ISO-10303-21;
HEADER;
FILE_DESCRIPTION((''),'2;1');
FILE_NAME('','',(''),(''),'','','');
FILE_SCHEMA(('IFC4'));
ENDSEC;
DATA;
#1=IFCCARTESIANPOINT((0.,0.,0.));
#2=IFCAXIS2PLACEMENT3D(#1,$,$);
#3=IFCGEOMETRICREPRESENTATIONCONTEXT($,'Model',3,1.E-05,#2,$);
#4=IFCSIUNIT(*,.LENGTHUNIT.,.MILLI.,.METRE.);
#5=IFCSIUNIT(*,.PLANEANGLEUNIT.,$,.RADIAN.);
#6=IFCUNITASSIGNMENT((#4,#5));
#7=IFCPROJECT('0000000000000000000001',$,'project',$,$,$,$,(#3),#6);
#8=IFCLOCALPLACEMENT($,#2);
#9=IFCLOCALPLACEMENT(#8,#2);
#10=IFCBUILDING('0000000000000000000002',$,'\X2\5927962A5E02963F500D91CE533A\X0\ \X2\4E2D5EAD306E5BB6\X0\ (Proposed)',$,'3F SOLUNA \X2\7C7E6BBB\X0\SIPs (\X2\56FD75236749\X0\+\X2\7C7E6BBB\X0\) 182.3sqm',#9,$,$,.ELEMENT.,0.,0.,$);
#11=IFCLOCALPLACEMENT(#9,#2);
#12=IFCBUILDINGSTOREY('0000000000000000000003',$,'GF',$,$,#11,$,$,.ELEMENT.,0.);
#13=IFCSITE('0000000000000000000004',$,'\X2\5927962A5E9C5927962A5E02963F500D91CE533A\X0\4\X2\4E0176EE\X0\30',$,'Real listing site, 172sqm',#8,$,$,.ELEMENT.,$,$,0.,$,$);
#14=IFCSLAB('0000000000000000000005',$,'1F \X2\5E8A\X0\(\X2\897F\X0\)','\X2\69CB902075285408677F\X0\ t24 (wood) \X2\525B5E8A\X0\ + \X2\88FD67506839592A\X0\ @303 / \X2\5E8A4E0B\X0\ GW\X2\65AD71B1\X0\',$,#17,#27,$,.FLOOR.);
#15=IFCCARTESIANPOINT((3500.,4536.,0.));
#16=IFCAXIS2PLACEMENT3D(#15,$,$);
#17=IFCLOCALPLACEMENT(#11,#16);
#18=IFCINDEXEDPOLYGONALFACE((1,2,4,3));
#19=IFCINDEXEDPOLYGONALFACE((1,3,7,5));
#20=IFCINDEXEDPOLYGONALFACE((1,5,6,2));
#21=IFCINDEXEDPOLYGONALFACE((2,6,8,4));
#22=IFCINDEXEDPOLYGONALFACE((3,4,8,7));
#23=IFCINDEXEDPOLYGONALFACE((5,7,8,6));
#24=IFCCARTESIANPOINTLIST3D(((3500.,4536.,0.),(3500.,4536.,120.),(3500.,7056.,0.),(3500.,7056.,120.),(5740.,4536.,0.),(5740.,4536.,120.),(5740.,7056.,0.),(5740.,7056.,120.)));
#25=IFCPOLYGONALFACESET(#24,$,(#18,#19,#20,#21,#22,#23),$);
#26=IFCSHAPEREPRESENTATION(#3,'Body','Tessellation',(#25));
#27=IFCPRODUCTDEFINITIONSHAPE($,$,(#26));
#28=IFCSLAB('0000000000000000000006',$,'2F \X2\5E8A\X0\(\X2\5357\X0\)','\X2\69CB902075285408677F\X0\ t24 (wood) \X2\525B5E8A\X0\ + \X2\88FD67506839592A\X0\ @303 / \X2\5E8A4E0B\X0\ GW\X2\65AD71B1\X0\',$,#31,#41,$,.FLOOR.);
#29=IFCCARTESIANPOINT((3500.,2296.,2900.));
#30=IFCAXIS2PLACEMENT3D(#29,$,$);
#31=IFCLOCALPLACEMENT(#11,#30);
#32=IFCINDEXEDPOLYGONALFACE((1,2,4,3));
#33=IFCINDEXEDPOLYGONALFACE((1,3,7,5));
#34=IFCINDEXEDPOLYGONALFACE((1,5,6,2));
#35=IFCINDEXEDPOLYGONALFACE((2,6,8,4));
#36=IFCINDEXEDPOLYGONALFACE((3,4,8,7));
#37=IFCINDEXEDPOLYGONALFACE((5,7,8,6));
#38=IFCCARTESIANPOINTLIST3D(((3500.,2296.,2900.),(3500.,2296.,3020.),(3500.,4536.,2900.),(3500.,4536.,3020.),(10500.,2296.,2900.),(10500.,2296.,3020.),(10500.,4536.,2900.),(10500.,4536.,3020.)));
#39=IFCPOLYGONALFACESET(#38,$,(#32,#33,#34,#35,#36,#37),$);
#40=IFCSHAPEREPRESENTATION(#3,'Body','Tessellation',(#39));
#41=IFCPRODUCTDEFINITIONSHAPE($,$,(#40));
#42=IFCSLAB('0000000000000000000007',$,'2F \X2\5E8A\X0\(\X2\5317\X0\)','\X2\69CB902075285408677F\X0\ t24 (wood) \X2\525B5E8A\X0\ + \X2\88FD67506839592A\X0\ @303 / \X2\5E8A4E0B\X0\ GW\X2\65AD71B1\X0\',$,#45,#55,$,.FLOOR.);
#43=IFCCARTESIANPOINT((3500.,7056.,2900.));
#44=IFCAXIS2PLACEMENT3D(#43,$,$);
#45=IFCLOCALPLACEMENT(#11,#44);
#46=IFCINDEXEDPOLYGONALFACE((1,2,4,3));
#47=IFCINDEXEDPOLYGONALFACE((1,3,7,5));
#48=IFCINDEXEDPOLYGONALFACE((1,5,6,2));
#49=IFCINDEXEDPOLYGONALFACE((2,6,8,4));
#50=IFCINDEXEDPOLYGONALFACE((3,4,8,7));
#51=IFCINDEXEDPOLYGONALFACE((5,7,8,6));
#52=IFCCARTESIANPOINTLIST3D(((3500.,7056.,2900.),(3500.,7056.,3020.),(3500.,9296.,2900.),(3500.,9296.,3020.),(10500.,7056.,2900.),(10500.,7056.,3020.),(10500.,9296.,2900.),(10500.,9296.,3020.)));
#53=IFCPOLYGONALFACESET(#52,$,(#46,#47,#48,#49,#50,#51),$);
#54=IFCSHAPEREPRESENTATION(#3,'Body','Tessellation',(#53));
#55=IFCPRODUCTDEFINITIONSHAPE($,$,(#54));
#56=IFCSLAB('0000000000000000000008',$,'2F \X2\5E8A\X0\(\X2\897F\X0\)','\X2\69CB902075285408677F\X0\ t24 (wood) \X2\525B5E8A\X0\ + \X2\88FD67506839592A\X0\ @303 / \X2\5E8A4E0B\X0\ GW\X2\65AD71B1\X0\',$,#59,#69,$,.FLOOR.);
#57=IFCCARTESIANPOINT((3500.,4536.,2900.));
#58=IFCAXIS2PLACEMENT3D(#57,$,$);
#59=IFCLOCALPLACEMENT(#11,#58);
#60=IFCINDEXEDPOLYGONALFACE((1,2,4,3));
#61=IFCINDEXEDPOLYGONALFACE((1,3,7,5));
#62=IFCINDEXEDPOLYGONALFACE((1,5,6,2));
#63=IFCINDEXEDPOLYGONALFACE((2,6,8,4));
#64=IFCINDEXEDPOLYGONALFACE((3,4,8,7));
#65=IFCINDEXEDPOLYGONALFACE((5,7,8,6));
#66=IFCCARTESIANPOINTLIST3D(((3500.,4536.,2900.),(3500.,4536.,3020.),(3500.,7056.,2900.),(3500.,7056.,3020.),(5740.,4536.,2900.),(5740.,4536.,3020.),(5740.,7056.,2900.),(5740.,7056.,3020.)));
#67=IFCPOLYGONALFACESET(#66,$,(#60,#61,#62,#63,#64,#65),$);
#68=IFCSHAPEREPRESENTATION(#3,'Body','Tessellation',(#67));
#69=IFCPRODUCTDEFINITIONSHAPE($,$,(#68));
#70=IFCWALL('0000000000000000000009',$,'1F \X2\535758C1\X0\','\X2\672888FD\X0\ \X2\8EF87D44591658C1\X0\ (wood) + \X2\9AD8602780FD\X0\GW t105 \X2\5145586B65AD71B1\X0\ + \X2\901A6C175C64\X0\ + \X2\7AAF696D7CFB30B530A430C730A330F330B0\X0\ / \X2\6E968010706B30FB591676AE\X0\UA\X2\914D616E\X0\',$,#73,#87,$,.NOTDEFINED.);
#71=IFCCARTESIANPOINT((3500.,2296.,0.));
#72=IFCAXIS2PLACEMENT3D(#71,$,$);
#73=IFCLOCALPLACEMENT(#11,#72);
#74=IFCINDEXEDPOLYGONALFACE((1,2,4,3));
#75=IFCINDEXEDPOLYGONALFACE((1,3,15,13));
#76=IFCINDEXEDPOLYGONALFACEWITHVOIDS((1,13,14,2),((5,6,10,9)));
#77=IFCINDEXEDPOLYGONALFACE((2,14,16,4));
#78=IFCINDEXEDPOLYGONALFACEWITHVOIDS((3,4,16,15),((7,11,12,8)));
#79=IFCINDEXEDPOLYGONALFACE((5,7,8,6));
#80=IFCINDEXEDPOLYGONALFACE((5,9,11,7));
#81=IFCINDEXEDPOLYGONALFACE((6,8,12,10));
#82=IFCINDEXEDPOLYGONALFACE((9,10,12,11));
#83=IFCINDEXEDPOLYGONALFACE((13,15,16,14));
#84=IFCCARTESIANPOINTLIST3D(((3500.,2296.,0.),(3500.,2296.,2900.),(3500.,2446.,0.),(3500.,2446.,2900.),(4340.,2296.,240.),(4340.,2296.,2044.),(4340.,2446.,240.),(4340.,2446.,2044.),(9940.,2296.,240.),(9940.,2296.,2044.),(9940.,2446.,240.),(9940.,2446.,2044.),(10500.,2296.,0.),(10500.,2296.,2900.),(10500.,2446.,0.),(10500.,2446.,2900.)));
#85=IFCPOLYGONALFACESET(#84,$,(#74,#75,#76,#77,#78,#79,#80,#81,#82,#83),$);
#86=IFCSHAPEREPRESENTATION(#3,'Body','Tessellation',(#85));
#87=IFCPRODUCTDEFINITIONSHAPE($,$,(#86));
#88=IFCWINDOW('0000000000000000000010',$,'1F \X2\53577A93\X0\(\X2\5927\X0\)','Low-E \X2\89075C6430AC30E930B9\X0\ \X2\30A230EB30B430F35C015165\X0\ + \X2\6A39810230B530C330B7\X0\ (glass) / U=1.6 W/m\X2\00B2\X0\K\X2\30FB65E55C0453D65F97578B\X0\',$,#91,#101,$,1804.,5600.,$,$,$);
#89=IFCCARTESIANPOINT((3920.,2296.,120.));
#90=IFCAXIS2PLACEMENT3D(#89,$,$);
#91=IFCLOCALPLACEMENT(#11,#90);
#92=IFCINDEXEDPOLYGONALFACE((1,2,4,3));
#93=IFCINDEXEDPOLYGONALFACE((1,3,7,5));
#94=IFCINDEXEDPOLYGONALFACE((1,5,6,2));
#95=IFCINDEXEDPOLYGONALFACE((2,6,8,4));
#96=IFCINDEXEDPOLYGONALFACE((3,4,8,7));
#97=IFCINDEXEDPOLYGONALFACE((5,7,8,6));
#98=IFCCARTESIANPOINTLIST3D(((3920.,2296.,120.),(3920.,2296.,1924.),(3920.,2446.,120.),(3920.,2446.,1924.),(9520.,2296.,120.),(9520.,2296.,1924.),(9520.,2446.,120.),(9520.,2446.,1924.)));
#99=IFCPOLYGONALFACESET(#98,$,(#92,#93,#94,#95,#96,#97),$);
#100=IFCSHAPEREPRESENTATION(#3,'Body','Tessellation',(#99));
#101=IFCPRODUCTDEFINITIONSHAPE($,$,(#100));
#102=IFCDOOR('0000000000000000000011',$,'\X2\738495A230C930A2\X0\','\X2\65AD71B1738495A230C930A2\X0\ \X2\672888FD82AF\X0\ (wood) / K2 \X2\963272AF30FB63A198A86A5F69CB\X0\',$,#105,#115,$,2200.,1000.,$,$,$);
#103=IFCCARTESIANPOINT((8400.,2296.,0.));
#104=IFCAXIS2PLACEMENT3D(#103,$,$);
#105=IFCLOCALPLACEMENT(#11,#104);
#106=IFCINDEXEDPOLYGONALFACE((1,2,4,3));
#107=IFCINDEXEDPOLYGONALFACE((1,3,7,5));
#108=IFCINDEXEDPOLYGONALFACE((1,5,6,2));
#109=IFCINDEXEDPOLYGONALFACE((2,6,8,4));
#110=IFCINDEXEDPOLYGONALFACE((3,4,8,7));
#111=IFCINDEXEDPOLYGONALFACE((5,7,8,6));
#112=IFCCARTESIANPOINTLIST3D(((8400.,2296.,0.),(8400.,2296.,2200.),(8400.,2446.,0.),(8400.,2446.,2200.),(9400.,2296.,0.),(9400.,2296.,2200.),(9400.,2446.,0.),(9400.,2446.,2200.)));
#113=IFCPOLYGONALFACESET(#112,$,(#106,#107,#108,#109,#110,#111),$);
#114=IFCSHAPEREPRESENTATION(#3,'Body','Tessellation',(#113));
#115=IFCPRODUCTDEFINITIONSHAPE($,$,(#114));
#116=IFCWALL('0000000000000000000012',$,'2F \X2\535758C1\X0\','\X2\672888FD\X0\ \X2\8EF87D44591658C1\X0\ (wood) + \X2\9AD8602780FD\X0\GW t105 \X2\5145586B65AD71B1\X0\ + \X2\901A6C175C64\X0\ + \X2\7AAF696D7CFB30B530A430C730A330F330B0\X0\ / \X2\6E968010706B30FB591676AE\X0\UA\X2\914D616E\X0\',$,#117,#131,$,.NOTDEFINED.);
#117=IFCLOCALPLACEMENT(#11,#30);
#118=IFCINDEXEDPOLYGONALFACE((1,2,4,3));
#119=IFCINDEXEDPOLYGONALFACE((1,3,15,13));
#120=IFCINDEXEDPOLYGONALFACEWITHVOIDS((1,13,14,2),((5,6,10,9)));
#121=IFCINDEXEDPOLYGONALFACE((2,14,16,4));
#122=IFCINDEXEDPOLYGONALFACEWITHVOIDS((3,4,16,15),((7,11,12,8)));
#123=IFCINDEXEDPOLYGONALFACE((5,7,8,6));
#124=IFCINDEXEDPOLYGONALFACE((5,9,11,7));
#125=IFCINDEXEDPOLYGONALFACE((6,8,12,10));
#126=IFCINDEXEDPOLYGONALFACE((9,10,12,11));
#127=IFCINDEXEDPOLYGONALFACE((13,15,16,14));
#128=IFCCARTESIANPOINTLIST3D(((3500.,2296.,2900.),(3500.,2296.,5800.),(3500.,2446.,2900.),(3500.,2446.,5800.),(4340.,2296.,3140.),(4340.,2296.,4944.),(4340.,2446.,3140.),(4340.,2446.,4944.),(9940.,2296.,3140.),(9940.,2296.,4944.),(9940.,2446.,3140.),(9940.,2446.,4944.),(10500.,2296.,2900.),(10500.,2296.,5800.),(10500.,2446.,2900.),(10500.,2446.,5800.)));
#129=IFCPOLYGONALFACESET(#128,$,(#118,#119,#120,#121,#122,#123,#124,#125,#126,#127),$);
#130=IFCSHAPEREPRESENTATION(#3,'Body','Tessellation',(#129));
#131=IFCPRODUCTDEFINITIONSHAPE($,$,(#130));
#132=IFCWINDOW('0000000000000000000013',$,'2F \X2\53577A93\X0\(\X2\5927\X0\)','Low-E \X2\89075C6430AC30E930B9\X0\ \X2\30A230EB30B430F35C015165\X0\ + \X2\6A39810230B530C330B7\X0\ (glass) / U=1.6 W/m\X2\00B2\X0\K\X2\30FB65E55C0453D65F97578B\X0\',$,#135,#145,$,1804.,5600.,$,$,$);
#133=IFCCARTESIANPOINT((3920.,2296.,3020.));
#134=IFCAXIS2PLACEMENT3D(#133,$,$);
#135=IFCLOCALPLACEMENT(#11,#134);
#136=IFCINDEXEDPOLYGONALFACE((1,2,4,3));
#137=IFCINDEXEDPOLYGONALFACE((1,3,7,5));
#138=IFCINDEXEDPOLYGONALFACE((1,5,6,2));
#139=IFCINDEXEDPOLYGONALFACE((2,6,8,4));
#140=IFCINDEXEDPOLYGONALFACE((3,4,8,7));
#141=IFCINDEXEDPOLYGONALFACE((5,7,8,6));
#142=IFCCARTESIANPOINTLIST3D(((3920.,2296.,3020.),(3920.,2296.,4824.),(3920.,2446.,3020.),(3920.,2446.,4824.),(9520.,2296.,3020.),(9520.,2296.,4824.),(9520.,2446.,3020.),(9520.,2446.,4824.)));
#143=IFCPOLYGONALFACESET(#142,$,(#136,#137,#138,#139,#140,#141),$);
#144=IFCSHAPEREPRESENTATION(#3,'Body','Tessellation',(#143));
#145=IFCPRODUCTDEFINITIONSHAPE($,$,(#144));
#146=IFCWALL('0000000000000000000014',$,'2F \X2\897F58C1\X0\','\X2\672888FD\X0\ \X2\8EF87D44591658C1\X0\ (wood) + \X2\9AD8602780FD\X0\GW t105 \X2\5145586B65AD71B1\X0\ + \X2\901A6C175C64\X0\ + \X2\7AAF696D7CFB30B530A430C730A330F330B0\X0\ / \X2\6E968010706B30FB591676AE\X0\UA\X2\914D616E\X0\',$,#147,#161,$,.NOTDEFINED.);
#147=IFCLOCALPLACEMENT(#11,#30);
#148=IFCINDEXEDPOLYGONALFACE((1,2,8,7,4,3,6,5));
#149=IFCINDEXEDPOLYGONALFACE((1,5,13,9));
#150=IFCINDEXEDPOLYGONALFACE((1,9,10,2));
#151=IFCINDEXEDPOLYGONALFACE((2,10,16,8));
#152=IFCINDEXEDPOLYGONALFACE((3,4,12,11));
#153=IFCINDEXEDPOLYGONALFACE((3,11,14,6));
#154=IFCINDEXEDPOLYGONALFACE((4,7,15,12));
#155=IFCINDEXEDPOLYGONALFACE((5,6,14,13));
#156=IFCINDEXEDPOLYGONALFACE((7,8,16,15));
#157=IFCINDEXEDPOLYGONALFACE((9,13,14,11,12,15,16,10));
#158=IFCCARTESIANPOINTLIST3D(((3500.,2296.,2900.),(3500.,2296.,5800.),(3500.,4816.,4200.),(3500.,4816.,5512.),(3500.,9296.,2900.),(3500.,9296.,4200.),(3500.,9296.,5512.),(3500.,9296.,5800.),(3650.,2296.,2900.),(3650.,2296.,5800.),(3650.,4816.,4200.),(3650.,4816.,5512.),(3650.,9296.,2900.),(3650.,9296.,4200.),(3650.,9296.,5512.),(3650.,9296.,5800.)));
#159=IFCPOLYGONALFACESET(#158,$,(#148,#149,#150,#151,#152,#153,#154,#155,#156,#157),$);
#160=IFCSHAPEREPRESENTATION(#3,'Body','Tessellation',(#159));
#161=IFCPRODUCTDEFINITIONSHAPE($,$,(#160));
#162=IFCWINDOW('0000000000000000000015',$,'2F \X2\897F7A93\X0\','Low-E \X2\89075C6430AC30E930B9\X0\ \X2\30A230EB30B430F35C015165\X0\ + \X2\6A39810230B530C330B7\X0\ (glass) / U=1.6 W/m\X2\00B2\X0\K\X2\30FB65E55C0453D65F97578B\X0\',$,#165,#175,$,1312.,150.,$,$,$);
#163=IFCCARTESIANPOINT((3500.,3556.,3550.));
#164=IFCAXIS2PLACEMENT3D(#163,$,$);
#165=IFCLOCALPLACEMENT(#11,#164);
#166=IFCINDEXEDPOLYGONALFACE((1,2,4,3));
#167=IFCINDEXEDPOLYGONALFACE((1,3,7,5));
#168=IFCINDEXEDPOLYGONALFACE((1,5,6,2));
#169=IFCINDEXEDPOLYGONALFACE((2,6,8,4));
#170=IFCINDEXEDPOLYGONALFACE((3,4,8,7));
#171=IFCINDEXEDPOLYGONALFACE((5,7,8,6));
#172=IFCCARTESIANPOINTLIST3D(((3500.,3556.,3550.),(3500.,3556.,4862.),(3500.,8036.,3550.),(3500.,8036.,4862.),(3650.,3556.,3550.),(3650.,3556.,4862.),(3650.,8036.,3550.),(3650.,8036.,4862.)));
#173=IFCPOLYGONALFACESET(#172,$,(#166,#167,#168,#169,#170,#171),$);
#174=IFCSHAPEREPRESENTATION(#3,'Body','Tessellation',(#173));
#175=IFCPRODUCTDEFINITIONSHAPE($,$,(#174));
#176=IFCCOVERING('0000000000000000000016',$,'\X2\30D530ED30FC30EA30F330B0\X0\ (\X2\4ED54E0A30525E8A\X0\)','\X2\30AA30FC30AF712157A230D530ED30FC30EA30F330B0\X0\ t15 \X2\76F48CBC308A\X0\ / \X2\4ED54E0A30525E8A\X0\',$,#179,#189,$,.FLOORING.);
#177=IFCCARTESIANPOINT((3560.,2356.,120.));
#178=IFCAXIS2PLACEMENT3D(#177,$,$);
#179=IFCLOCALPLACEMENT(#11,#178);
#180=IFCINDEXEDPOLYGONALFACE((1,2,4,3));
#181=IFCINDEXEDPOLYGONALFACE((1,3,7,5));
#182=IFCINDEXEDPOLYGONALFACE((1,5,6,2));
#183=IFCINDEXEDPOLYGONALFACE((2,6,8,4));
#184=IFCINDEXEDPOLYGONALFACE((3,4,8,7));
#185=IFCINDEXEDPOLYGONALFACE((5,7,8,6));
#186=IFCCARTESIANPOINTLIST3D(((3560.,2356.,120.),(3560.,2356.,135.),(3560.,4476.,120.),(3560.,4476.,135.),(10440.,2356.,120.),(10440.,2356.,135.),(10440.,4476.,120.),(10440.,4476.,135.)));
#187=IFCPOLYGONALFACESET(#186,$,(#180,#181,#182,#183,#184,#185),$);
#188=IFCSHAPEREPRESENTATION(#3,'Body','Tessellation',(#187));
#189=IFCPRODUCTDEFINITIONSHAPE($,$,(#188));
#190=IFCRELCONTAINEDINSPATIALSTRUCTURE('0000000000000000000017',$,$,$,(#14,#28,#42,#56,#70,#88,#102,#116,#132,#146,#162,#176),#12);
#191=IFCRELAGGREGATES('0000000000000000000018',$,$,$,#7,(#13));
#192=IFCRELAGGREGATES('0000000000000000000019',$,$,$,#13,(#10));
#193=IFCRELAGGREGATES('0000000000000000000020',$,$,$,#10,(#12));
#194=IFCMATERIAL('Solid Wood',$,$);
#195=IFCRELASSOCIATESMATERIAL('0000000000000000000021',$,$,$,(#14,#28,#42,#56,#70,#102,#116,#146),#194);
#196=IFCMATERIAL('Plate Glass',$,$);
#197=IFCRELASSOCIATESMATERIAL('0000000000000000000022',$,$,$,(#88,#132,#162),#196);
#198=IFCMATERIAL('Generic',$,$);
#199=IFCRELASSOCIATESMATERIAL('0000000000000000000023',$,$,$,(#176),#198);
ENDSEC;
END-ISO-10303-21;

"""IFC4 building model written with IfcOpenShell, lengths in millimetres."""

from ifc_helpers import new_model, si_unit, frame, frame_2d, origin, place, context, project, spatial, rectangle, extrude, material, element, fill, save


model = new_model("IFC4")

# Units and contexts
model_context = context("Model", 3, precision=1e-05, world=origin())
ifc_project = project(units=[si_unit("LENGTHUNIT", "METRE", prefix="MILLI"), si_unit("PLANEANGLEUNIT", "RADIAN")], contexts=[model_context])

# Site, building, storey
site_placement = place(None, origin())
site = spatial("IfcSite", under=ifc_project, at=site_placement, Name="大阪府大阪市阿倍野区4丁目30", ObjectType="Real listing site, 172sqm", CompositionType="ELEMENT", RefElevation=0.0)
building_placement = place(site_placement, origin())
building = spatial("IfcBuilding", under=site, at=building_placement, Name="大阪市阿倍野区 中庭の家 (Proposed)", ObjectType="3F SOLUNA 籾殻SIPs (国産杉+籾殻) 182.3sqm", CompositionType="ELEMENT", ElevationOfRefHeight=0.0, ElevationOfTerrain=0.0)
storey_placement = place(building_placement, origin())
storey = spatial("IfcBuildingStorey", under=building, at=storey_placement, Name="GF", CompositionType="ELEMENT", Elevation=0.0)

# Slabs
ifc_material_1 = material(Name="Solid Wood")
slab_1_placement = place(storey_placement, frame((3500.0, 4536.0, 0.0)))
element("IfcSlab", 1, at=slab_1_placement, inside=storey, material=ifc_material_1, Name="1F 床(西)", Description="構造用合板 t24 (wood) 剛床 + 製材根太 @303 / 床下 GW断熱", PredefinedType="FLOOR", context=model_context, shape_type="SweptSolid", body=[
    extrude(rectangle(XDim=2240.0, YDim=2520.0, at=frame_2d((1120.0, 1260.0))), frame((3500.0, 4536.0, 0.0)), (0.0, 0.0, 1.0), 120.0),
])
slab_2_placement = place(storey_placement, frame((3500.0, 2296.0, 2900.0)))
element("IfcSlab", 2, at=slab_2_placement, inside=storey, material=ifc_material_1, Name="2F 床(南)", Description="構造用合板 t24 (wood) 剛床 + 製材根太 @303 / 床下 GW断熱", PredefinedType="FLOOR", context=model_context, shape_type="SweptSolid", body=[
    extrude(rectangle(XDim=7000.0, YDim=2240.0, at=frame_2d((3500.0, 1120.0))), frame((3500.0, 2296.0, 2900.0)), (0.0, 0.0, 1.0), 120.0),
])
slab_3_placement = place(storey_placement, frame((3500.0, 7056.0, 2900.0)))
element("IfcSlab", 3, at=slab_3_placement, inside=storey, material=ifc_material_1, Name="2F 床(北)", Description="構造用合板 t24 (wood) 剛床 + 製材根太 @303 / 床下 GW断熱", PredefinedType="FLOOR", context=model_context, shape_type="SweptSolid", body=[
    extrude(rectangle(XDim=7000.0, YDim=2240.0, at=frame_2d((3500.0, 1120.0))), frame((3500.0, 7056.0, 2900.0)), (0.0, 0.0, 1.0), 120.0),
])
slab_4_placement = place(storey_placement, frame((3500.0, 4536.0, 2900.0)))
element("IfcSlab", 4, at=slab_4_placement, inside=storey, material=ifc_material_1, Name="2F 床(西)", Description="構造用合板 t24 (wood) 剛床 + 製材根太 @303 / 床下 GW断熱", PredefinedType="FLOOR", context=model_context, shape_type="SweptSolid", body=[
    extrude(rectangle(XDim=2240.0, YDim=2520.0, at=frame_2d((1120.0, 1260.0))), frame((3500.0, 4536.0, 2900.0)), (0.0, 0.0, 1.0), 120.0),
])

# Wall, openings, window, door
wall_1_placement = place(storey_placement, frame((3500.0, 2296.0, 0.0)))
wall_1 = element("IfcWall", 5, at=wall_1_placement, inside=storey, material=ifc_material_1, Name="1F 南壁", Description="木製 軸組外壁 (wood) + 高性能GW t105 充填断熱 + 通気層 + 窯業系サイディング / 準耐火・外皮UA配慮", PredefinedType="NOTDEFINED", context=model_context, shape_type="SweptSolid", body=[
    extrude(rectangle(XDim=7000.0, YDim=150.0, at=frame_2d((3500.0, 75.0))), frame((3500.0, 2296.0, 0.0)), (0.0, 0.0, 1.0), 2900.0),
])
opening_1_placement = place(storey_placement, frame((3920.0, 2296.0, 120.0)))
opening_1 = element("IfcOpeningElement", 6, at=opening_1_placement, cuts=wall_1, PredefinedType="NOTDEFINED", context=model_context, shape_type="SweptSolid", body=[
    extrude(rectangle(XDim=5600.0, YDim=150.0, at=frame_2d((2800.0, 75.0))), frame((3920.0, 2296.0, 120.0)), (0.0, 0.0, 1.0), 1804.0),
])
opening_2_placement = place(storey_placement, frame((8400.0, 2296.0, 0.0)))
opening_2 = element("IfcOpeningElement", 7, at=opening_2_placement, cuts=wall_1, PredefinedType="NOTDEFINED", context=model_context, shape_type="SweptSolid", body=[
    extrude(rectangle(XDim=1000.0, YDim=150.0, at=frame_2d((500.0, 75.0))), frame((8400.0, 2296.0, 0.0)), (0.0, 0.0, 1.0), 2200.0),
])
ifc_material_2 = material(Name="Plate Glass")
window_1_placement = place(storey_placement, frame((3920.0, 2296.0, 120.0)))
window_1 = element("IfcWindow", 8, at=window_1_placement, inside=storey, material=ifc_material_2, Name="1F 南窓(大)", Description="Low-E 複層ガラス アルゴン封入 + 樹脂サッシ (glass) / U=1.6 W/m²K・日射取得型", OverallHeight=1804.0, OverallWidth=5600.0, context=model_context, shape_type="SweptSolid", body=[
    extrude(rectangle(XDim=5600.0, YDim=150.0, at=frame_2d((2800.0, 75.0))), frame((3920.0, 2296.0, 120.0)), (0.0, 0.0, 1.0), 1804.0),
])
fill(opening_1, window_1)
door_placement = place(storey_placement, frame((8400.0, 2296.0, 0.0)))
door = element("IfcDoor", 9, at=door_placement, inside=storey, material=ifc_material_1, Name="玄関ドア", Description="断熱玄関ドア 木製芯 (wood) / K2 防犯・採風機構", OverallHeight=2200.0, OverallWidth=1000.0, context=model_context, shape_type="SweptSolid", body=[
    extrude(rectangle(XDim=1000.0, YDim=150.0, at=frame_2d((500.0, 75.0))), frame((8400.0, 2296.0, 0.0)), (0.0, 0.0, 1.0), 2200.0),
])
fill(opening_2, door)

# Wall, opening, window
wall_2_placement = place(storey_placement, frame((3500.0, 2296.0, 2900.0)))
wall_2 = element("IfcWall", 10, at=wall_2_placement, inside=storey, material=ifc_material_1, Name="2F 南壁", Description="木製 軸組外壁 (wood) + 高性能GW t105 充填断熱 + 通気層 + 窯業系サイディング / 準耐火・外皮UA配慮", PredefinedType="NOTDEFINED", context=model_context, shape_type="SweptSolid", body=[
    extrude(rectangle(XDim=7000.0, YDim=150.0, at=frame_2d((3500.0, 75.0))), frame((3500.0, 2296.0, 2900.0)), (0.0, 0.0, 1.0), 2900.0),
])
opening_3_placement = place(storey_placement, frame((3920.0, 2296.0, 3020.0)))
opening_3 = element("IfcOpeningElement", 11, at=opening_3_placement, cuts=wall_2, PredefinedType="NOTDEFINED", context=model_context, shape_type="SweptSolid", body=[
    extrude(rectangle(XDim=5600.0, YDim=150.0, at=frame_2d((2800.0, 75.0))), frame((3920.0, 2296.0, 3020.0)), (0.0, 0.0, 1.0), 1804.0),
])
window_2_placement = place(storey_placement, frame((3920.0, 2296.0, 3020.0)))
window_2 = element("IfcWindow", 12, at=window_2_placement, inside=storey, material=ifc_material_2, Name="2F 南窓(大)", Description="Low-E 複層ガラス アルゴン封入 + 樹脂サッシ (glass) / U=1.6 W/m²K・日射取得型", OverallHeight=1804.0, OverallWidth=5600.0, context=model_context, shape_type="SweptSolid", body=[
    extrude(rectangle(XDim=5600.0, YDim=150.0, at=frame_2d((2800.0, 75.0))), frame((3920.0, 2296.0, 3020.0)), (0.0, 0.0, 1.0), 1804.0),
])
fill(opening_3, window_2)

# Wall, opening, window
wall_3_placement = place(storey_placement, frame((3500.0, 2296.0, 2900.0)))
wall_3 = element("IfcWall", 13, at=wall_3_placement, inside=storey, material=ifc_material_1, Name="2F 西壁", Description="木製 軸組外壁 (wood) + 高性能GW t105 充填断熱 + 通気層 + 窯業系サイディング / 準耐火・外皮UA配慮", PredefinedType="NOTDEFINED", context=model_context, shape_type="SweptSolid", body=[
    extrude(rectangle(XDim=150.0, YDim=7000.0, at=frame_2d((75.0, 3500.0))), frame((3500.0, 2296.0, 2900.0)), (0.0, 0.0, 1.0), 2900.0),
])
opening_4_placement = place(storey_placement, frame((3500.0, 3556.0, 3550.0)))
opening_4 = element("IfcOpeningElement", 14, at=opening_4_placement, cuts=wall_3, PredefinedType="NOTDEFINED", context=model_context, shape_type="SweptSolid", body=[
    extrude(rectangle(XDim=150.0, YDim=4480.0, at=frame_2d((75.0, 2240.0))), frame((3500.0, 3556.0, 3550.0)), (0.0, 0.0, 1.0), 1312.0),
])
window_3_placement = place(storey_placement, frame((3500.0, 3556.0, 3550.0)))
window_3 = element("IfcWindow", 15, at=window_3_placement, inside=storey, material=ifc_material_2, Name="2F 西窓", Description="Low-E 複層ガラス アルゴン封入 + 樹脂サッシ (glass) / U=1.6 W/m²K・日射取得型", OverallHeight=1312.0, OverallWidth=150.0, context=model_context, shape_type="SweptSolid", body=[
    extrude(rectangle(XDim=150.0, YDim=4480.0, at=frame_2d((75.0, 2240.0))), frame((3500.0, 3556.0, 3550.0)), (0.0, 0.0, 1.0), 1312.0),
])
fill(opening_4, window_3)

# Covering
ifc_material_3 = material(Name="Generic")
covering_1_placement = place(storey_placement, frame((3560.0, 2356.0, 120.0)))
element("IfcCovering", 16, at=covering_1_placement, inside=storey, material=ifc_material_3, Name="フローリング (仕上げ床)", Description="オーク無垢フローリング t15 直貼り / 仕上げ床", PredefinedType="FLOORING", context=model_context, shape_type="SweptSolid", body=[
    extrude(rectangle(XDim=6880.0, YDim=2120.0, at=frame_2d((3440.0, 1060.0))), frame((3560.0, 2356.0, 120.0)), (0.0, 0.0, 1.0), 15.0),
])

save(model, "model.ifc")
